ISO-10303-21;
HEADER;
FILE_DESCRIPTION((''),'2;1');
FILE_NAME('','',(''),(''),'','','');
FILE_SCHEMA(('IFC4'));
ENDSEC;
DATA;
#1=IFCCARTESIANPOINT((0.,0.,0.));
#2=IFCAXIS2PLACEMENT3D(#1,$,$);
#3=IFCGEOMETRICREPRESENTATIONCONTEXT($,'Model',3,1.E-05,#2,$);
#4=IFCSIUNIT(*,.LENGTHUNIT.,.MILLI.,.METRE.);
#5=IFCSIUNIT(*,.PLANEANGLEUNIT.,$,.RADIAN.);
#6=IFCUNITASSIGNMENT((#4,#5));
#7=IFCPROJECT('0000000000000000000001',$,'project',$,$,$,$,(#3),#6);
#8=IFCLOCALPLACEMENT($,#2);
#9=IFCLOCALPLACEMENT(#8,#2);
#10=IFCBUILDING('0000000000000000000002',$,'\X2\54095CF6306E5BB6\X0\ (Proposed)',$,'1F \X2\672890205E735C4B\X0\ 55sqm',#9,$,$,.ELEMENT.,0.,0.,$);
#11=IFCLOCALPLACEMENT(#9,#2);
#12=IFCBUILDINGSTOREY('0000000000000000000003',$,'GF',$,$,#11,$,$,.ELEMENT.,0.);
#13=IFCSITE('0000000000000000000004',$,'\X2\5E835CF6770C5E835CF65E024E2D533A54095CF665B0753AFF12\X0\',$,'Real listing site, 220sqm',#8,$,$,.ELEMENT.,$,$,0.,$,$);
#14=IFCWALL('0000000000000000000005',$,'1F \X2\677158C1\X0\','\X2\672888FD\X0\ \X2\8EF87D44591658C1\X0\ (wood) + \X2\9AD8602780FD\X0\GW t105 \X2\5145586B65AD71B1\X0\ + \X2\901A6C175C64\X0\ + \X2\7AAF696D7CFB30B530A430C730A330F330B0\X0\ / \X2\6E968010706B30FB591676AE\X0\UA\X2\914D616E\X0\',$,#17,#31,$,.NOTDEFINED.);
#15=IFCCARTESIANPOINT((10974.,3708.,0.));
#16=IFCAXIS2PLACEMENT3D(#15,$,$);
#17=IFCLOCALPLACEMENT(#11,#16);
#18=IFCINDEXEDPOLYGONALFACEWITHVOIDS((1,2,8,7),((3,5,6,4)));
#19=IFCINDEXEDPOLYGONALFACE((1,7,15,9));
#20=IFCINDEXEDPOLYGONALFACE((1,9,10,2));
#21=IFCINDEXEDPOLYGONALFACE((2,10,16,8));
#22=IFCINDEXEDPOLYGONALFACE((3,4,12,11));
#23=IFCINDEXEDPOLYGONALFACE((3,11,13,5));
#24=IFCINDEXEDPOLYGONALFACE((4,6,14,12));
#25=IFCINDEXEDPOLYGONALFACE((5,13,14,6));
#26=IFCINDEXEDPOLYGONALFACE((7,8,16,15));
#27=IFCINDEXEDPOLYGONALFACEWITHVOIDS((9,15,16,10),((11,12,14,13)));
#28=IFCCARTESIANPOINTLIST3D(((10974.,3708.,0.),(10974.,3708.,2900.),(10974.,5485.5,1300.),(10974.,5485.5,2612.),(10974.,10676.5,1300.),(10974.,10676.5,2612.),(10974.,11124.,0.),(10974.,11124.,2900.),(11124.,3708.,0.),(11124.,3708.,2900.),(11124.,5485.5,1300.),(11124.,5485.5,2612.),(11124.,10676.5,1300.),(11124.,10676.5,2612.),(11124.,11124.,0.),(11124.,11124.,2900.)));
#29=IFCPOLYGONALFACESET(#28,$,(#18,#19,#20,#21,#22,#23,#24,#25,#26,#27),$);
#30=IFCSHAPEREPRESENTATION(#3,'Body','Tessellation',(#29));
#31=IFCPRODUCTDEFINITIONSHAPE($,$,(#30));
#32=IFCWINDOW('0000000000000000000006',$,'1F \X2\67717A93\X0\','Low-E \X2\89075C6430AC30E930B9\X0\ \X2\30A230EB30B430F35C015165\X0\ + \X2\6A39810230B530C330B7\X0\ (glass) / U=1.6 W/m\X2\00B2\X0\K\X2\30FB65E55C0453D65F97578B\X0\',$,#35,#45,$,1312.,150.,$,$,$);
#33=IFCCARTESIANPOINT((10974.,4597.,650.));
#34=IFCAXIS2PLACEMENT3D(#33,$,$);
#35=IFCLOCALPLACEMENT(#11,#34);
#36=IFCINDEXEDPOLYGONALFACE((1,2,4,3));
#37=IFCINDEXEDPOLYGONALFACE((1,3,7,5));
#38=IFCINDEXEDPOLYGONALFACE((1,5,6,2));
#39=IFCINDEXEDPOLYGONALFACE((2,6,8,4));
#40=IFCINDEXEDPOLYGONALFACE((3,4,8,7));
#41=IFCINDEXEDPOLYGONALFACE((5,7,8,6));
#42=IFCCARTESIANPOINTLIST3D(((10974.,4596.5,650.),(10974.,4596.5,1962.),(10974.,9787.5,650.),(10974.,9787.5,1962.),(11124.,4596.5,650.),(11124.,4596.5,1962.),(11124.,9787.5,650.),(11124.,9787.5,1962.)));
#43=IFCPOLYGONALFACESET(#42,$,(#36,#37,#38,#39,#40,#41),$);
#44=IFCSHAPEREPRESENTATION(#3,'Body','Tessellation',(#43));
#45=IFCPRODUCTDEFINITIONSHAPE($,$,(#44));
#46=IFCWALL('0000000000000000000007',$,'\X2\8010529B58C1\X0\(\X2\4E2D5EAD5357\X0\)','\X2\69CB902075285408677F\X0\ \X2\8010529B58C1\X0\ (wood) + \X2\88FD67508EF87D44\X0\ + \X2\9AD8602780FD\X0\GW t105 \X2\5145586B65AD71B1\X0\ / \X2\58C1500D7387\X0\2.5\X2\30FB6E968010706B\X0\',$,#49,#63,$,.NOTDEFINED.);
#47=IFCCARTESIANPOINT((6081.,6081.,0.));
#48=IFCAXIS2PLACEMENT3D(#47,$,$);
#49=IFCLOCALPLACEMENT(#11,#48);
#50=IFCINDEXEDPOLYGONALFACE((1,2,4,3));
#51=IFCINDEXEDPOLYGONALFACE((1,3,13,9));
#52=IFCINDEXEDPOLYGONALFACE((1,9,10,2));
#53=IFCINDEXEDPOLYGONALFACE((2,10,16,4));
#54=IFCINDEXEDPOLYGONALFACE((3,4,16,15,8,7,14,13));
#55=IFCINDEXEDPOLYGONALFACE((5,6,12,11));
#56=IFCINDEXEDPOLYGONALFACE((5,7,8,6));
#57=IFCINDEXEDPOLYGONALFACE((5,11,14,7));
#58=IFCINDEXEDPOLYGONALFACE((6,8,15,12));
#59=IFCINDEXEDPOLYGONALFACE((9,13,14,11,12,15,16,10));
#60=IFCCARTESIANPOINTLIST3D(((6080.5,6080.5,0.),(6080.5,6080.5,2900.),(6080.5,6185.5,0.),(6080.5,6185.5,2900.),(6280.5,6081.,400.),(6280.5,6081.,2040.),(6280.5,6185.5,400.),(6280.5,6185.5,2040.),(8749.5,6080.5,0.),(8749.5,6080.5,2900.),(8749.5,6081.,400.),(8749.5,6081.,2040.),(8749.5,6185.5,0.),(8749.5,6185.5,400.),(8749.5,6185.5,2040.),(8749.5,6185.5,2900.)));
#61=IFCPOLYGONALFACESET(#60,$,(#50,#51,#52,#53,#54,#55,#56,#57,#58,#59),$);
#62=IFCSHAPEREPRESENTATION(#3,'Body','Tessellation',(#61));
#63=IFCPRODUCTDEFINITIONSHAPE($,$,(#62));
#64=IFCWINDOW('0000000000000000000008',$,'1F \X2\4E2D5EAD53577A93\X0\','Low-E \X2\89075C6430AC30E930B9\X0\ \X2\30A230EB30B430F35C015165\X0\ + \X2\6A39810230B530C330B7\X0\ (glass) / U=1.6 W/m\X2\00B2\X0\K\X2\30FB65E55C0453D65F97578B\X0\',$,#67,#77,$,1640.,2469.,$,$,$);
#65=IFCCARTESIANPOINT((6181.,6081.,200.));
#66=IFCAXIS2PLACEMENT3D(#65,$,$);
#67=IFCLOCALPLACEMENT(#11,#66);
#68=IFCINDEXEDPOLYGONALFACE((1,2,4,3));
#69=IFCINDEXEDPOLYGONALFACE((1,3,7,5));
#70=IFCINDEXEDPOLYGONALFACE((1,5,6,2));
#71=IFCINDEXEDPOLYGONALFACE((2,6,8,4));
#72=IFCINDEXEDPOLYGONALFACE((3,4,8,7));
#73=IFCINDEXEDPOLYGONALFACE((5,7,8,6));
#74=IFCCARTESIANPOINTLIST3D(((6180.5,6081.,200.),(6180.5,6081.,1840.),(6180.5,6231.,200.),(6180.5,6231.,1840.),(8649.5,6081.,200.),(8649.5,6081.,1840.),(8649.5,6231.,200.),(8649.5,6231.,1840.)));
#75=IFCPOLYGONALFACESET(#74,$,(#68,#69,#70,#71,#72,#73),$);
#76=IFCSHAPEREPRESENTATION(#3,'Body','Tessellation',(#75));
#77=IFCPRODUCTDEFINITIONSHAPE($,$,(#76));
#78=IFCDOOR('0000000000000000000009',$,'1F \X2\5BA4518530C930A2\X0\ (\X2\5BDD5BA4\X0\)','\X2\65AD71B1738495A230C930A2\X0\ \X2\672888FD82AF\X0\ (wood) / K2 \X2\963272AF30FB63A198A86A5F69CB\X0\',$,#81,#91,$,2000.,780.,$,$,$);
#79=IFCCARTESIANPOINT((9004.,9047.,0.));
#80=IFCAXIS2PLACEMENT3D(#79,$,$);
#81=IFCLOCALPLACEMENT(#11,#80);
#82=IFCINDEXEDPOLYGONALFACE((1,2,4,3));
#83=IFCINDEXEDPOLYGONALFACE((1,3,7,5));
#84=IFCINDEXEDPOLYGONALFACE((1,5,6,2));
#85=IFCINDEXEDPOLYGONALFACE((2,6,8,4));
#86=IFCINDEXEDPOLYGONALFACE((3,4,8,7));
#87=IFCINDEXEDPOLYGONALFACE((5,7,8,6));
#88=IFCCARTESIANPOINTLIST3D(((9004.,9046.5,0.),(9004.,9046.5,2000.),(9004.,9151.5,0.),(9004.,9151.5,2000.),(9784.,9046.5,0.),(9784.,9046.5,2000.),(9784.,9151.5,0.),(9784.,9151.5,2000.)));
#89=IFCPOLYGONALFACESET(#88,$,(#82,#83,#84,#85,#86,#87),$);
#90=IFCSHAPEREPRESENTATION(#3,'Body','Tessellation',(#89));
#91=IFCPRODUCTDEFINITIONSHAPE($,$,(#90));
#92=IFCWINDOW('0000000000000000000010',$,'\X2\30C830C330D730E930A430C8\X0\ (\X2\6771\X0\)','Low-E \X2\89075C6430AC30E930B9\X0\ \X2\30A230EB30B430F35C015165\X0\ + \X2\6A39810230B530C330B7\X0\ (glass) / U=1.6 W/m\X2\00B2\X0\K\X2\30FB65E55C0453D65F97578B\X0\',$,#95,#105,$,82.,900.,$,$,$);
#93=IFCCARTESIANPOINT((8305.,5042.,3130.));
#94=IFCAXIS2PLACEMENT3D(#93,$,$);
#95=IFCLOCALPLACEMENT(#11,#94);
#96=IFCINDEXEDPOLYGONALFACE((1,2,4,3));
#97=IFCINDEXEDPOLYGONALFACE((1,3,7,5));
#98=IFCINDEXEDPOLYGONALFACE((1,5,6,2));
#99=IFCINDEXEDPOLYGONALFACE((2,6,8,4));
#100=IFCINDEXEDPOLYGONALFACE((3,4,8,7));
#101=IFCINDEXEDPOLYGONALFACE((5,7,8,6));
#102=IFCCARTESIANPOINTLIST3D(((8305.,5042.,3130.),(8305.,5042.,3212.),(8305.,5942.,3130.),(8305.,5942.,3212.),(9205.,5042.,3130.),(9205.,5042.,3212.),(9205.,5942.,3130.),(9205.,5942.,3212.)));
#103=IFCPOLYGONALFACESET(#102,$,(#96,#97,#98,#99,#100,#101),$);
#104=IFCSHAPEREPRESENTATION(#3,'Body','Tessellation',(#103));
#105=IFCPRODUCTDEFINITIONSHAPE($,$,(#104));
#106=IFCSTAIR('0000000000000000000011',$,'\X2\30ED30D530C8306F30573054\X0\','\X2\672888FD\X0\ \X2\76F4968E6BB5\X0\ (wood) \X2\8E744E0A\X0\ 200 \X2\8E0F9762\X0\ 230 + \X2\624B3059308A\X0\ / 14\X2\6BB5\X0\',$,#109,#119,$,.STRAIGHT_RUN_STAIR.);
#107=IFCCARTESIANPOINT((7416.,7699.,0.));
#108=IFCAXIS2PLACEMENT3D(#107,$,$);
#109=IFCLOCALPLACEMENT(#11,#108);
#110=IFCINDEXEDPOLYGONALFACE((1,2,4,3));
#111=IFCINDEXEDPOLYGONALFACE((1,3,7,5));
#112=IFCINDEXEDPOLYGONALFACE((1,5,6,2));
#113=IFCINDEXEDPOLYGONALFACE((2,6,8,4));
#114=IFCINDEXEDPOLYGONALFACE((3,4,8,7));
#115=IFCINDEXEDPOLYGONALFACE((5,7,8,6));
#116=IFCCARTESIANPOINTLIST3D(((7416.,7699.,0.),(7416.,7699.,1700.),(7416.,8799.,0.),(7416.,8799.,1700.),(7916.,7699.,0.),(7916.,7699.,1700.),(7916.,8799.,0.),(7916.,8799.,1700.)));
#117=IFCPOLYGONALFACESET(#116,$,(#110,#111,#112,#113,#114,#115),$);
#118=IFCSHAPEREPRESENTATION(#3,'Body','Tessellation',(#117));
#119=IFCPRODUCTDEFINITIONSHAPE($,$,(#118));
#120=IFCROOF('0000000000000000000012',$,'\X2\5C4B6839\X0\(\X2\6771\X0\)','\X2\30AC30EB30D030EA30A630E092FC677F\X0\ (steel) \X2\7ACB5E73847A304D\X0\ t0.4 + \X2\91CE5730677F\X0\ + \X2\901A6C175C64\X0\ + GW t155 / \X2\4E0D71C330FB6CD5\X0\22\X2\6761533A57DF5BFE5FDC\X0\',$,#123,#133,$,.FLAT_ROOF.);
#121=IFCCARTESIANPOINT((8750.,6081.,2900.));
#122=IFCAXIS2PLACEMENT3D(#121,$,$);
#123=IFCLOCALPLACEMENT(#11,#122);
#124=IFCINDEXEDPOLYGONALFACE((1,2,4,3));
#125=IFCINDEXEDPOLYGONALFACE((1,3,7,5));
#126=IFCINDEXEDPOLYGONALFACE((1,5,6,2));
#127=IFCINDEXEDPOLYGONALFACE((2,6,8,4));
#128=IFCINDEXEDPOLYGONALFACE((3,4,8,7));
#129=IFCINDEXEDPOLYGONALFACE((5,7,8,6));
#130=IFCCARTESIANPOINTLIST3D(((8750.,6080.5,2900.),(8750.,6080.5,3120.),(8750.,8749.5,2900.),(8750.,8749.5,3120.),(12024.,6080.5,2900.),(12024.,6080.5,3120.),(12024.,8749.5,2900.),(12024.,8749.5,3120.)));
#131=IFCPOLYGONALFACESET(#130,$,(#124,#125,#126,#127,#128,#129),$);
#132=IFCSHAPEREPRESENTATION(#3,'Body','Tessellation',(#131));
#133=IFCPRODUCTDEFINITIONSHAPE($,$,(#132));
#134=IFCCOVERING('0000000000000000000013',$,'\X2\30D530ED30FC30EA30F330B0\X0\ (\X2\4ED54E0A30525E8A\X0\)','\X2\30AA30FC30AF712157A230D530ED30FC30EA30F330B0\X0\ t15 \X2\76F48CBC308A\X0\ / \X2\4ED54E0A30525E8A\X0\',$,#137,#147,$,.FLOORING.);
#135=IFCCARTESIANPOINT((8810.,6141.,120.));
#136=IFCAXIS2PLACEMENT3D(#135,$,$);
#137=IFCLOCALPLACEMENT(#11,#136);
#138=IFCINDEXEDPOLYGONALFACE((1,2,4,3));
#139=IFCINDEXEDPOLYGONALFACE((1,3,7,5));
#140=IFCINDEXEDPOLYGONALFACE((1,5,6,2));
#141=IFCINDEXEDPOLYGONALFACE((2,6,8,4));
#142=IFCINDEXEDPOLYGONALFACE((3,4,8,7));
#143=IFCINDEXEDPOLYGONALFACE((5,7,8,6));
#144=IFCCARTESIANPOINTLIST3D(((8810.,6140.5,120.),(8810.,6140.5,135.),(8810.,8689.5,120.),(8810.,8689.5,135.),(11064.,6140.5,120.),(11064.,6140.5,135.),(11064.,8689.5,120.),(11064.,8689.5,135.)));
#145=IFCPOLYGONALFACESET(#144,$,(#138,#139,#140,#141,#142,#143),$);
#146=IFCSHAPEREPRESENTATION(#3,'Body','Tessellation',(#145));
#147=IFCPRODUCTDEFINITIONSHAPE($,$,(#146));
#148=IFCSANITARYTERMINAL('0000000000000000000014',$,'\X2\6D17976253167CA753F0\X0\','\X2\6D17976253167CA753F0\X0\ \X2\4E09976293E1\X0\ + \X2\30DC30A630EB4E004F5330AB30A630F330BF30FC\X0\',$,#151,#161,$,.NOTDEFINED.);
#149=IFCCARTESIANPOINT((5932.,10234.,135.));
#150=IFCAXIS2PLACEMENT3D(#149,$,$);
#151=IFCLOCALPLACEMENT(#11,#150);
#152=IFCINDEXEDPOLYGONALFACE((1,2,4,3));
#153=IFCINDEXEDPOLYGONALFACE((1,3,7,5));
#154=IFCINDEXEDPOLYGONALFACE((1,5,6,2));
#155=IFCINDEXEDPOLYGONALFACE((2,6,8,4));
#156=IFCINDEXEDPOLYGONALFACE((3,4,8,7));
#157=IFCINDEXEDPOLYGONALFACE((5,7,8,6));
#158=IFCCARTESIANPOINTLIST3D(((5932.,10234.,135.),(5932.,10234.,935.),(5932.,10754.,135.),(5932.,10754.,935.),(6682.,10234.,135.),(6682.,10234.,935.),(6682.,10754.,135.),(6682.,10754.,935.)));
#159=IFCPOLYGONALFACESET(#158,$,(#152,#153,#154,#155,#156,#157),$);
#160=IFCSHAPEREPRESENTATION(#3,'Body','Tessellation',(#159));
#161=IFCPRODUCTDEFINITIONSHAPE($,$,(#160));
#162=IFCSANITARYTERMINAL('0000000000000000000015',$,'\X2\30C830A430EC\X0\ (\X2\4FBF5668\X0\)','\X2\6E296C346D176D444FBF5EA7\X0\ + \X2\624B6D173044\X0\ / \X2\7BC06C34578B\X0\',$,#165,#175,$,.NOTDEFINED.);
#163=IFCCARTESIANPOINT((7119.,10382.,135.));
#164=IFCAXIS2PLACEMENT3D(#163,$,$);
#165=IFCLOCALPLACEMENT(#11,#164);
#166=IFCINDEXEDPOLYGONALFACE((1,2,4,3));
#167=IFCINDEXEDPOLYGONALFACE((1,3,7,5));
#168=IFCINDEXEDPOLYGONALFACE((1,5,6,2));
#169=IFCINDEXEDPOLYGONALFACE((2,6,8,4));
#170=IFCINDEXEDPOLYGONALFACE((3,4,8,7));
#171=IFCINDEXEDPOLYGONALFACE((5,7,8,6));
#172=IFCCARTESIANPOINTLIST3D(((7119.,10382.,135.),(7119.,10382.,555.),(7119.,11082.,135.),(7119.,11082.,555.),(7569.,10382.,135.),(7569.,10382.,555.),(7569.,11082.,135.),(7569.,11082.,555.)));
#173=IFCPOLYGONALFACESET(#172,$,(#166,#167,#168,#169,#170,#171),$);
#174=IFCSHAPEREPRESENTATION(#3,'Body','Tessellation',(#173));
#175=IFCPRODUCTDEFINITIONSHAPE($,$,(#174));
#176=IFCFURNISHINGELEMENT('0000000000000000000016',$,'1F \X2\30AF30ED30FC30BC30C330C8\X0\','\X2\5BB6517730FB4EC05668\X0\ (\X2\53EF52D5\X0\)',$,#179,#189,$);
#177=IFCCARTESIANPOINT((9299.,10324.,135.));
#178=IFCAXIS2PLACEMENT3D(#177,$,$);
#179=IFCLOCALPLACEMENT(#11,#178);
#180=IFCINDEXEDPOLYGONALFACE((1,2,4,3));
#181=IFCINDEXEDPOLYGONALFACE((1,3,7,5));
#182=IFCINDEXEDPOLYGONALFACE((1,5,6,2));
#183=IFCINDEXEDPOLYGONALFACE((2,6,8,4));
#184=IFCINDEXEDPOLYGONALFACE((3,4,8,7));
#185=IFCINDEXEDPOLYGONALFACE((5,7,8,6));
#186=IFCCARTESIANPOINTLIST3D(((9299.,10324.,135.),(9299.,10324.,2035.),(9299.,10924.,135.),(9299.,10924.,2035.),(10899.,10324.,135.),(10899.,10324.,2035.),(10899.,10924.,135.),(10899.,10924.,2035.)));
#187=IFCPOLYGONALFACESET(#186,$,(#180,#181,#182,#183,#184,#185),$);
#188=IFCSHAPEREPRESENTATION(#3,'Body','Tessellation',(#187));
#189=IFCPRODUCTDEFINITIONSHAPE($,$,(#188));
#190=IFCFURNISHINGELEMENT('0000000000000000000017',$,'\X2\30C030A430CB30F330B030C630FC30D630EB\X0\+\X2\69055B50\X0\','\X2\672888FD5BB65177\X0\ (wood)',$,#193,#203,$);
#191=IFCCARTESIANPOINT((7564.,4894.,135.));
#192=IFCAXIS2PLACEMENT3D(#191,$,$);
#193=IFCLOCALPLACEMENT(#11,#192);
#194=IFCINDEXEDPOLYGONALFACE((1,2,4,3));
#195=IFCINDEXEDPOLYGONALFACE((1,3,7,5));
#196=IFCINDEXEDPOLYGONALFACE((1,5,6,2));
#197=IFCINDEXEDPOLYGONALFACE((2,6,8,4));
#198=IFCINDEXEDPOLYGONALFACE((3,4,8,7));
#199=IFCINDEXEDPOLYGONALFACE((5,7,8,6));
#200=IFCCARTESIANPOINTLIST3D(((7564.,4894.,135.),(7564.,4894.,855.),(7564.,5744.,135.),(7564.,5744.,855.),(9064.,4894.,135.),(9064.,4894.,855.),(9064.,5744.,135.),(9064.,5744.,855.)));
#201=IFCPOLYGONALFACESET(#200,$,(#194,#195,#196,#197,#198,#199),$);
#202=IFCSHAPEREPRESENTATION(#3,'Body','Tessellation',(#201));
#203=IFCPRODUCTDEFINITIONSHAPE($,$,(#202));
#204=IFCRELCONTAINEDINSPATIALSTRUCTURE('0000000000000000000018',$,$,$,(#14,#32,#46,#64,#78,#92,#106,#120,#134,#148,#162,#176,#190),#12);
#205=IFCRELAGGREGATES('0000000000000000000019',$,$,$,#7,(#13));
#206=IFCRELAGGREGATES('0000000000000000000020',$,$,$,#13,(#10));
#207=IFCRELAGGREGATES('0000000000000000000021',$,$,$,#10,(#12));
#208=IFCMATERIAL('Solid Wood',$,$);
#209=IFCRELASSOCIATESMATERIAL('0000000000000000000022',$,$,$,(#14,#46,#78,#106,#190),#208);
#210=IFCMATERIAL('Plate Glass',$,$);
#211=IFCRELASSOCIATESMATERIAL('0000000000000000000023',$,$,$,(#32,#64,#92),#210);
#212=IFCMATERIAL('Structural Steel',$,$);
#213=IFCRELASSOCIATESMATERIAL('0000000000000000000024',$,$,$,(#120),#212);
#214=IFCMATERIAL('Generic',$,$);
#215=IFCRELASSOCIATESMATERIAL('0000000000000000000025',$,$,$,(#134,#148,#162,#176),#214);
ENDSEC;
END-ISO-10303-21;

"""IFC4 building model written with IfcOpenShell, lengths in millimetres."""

from ifc_helpers import new_model, si_unit, frame, frame_2d, origin, place, context, project, spatial, rectangle, extrude, material, element, fill, save


model = new_model("IFC4")

# Units and contexts
model_context = context("Model", 3, precision=1e-05, world=origin())
ifc_project = project(units=[si_unit("LENGTHUNIT", "METRE", prefix="MILLI"), si_unit("PLANEANGLEUNIT", "RADIAN")], contexts=[model_context])

# Site, building, storey
site_placement = place(None, origin())
site = spatial("IfcSite", under=ifc_project, at=site_placement, Name="広島県広島市中区吉島新町２", ObjectType="Real listing site, 220sqm", CompositionType="ELEMENT", RefElevation=0.0)
building_placement = place(site_placement, origin())
building = spatial("IfcBuilding", under=site, at=building_placement, Name="吉島の家 (Proposed)", ObjectType="1F 木造平屋 55sqm", CompositionType="ELEMENT", ElevationOfRefHeight=0.0, ElevationOfTerrain=0.0)
storey_placement = place(building_placement, origin())
storey = spatial("IfcBuildingStorey", under=building, at=storey_placement, Name="GF", CompositionType="ELEMENT", Elevation=0.0)

# Shared definitions
ifc_material_1 = material(Name="Solid Wood")

# Walls, openings, windows
wall_1_placement = place(storey_placement, frame((10974.0, 3708.0, 0.0)))
wall_1 = element("IfcWall", 1, at=wall_1_placement, inside=storey, material=ifc_material_1, Name="1F 東壁", Description="木製 軸組外壁 (wood) + 高性能GW t105 充填断熱 + 通気層 + 窯業系サイディング / 準耐火・外皮UA配慮", PredefinedType="NOTDEFINED", context=model_context, shape_type="SweptSolid", body=[
    extrude(rectangle(XDim=150.0, YDim=7416.0, at=frame_2d((75.0, 3708.0))), frame((10974.0, 3708.0, 0.0)), (0.0, 0.0, 1.0), 2900.0),
])
opening_1_placement = place(storey_placement, frame((10974.0, 4597.0, 650.0)))
opening_1 = element("IfcOpeningElement", 2, at=opening_1_placement, cuts=wall_1, PredefinedType="NOTDEFINED", context=model_context, shape_type="SweptSolid", body=[
    extrude(rectangle(XDim=150.0, YDim=5191.0, at=frame_2d((75.0, 2595.0))), frame((10974.0, 4597.0, 650.0)), (0.0, 0.0, 1.0), 1312.0),
])
ifc_material_2 = material(Name="Plate Glass")
window_1_placement = place(storey_placement, frame((10974.0, 4597.0, 650.0)))
window_1 = element("IfcWindow", 3, at=window_1_placement, inside=storey, material=ifc_material_2, Name="1F 東窓", Description="Low-E 複層ガラス アルゴン封入 + 樹脂サッシ (glass) / U=1.6 W/m²K・日射取得型", OverallHeight=1312.0, OverallWidth=150.0, context=model_context, shape_type="SweptSolid", body=[
    extrude(rectangle(XDim=150.0, YDim=5191.0, at=frame_2d((75.0, 2595.0))), frame((10974.0, 4597.0, 650.0)), (0.0, 0.0, 1.0), 1312.0),
])
fill(opening_1, window_1)
wall_2_placement = place(storey_placement, frame((6081.0, 6081.0, 0.0)))
wall_2 = element("IfcWall", 4, at=wall_2_placement, inside=storey, material=ifc_material_1, Name="耐力壁(中庭南)", Description="構造用合板 耐力壁 (wood) + 製材軸組 + 高性能GW t105 充填断熱 / 壁倍率2.5・準耐火", PredefinedType="NOTDEFINED", context=model_context, shape_type="SweptSolid", body=[
    extrude(rectangle(XDim=2669.0, YDim=105.0, at=frame_2d((1334.0, 52.0))), frame((6081.0, 6081.0, 0.0)), (0.0, 0.0, 1.0), 2900.0),
])
opening_2_placement = place(storey_placement, frame((6181.0, 6081.0, 200.0)))
opening_2 = element("IfcOpeningElement", 5, at=opening_2_placement, cuts=wall_2, PredefinedType="NOTDEFINED", context=model_context, shape_type="SweptSolid", body=[
    extrude(rectangle(XDim=2469.0, YDim=150.0, at=frame_2d((1234.0, 75.0))), frame((6181.0, 6081.0, 200.0)), (0.0, 0.0, 1.0), 1640.0),
])
window_2_placement = place(storey_placement, frame((6181.0, 6081.0, 200.0)))
window_2 = element("IfcWindow", 6, at=window_2_placement, inside=storey, material=ifc_material_2, Name="1F 中庭南窓", Description="Low-E 複層ガラス アルゴン封入 + 樹脂サッシ (glass) / U=1.6 W/m²K・日射取得型", OverallHeight=1640.0, OverallWidth=2469.0, context=model_context, shape_type="SweptSolid", body=[
    extrude(rectangle(XDim=2469.0, YDim=150.0, at=frame_2d((1234.0, 75.0))), frame((6181.0, 6081.0, 200.0)), (0.0, 0.0, 1.0), 1640.0),
])
fill(opening_2, window_2)

# Door
door_placement = place(storey_placement, frame((9004.0, 9047.0, 0.0)))
element("IfcDoor", 7, at=door_placement, inside=storey, material=ifc_material_1, Name="1F 室内ドア (寝室)", Description="断熱玄関ドア 木製芯 (wood) / K2 防犯・採風機構", OverallHeight=2000.0, OverallWidth=780.0, context=model_context, shape_type="SweptSolid", body=[
    extrude(rectangle(XDim=780.0, YDim=105.0, at=frame_2d((390.0, 52.0))), frame((9004.0, 9047.0, 0.0)), (0.0, 0.0, 1.0), 2000.0),
])

# Window
window_3_placement = place(storey_placement, frame((8305.0, 5042.0, 3130.0)))
element("IfcWindow", 8, at=window_3_placement, inside=storey, material=ifc_material_2, Name="トップライト (東)", Description="Low-E 複層ガラス アルゴン封入 + 樹脂サッシ (glass) / U=1.6 W/m²K・日射取得型", OverallHeight=82.0, OverallWidth=900.0, context=model_context, shape_type="SweptSolid", body=[
    extrude(rectangle(XDim=900.0, YDim=900.0, at=frame_2d((450.0, 450.0))), frame((8305.0, 5042.0, 3130.0)), (0.0, 0.0, 1.0), 82.0),
])

# Stair
stair_placement = place(storey_placement, frame((7416.0, 7699.0, 0.0)))
element("IfcStair", 9, at=stair_placement, inside=storey, material=ifc_material_1, Name="ロフトはしご", Description="木製 直階段 (wood) 蹴上 200 踏面 230 + 手すり / 14段", PredefinedType="STRAIGHT_RUN_STAIR", context=model_context, shape_type="SweptSolid", body=[
    extrude(rectangle(XDim=500.0, YDim=1100.0, at=frame_2d((250.0, 550.0))), frame((7416.0, 7699.0, 0.0)), (0.0, 0.0, 1.0), 1700.0),
])

# Roof
ifc_material_3 = material(Name="Structural Steel")
roof_placement = place(storey_placement, frame((8750.0, 6081.0, 2900.0)))
element("IfcRoof", 10, at=roof_placement, inside=storey, material=ifc_material_3, Name="屋根(東)", Description="ガルバリウム鋼板 (steel) 立平葺き t0.4 + 野地板 + 通気層 + GW t155 / 不燃・法22条区域対応", PredefinedType="FLAT_ROOF", context=model_context, shape_type="SweptSolid", body=[
    extrude(rectangle(XDim=3274.0, YDim=2669.0, at=frame_2d((1637.0, 1334.0))), frame((8750.0, 6081.0, 2900.0)), (0.0, 0.0, 1.0), 220.0),
])

# Covering
ifc_material_4 = material(Name="Generic")
covering_placement = place(storey_placement, frame((8810.0, 6141.0, 120.0)))
element("IfcCovering", 11, at=covering_placement, inside=storey, material=ifc_material_4, Name="フローリング (仕上げ床)", Description="オーク無垢フローリング t15 直貼り / 仕上げ床", PredefinedType="FLOORING", context=model_context, shape_type="SweptSolid", body=[
    extrude(rectangle(XDim=2254.0, YDim=2549.0, at=frame_2d((1127.0, 1274.0))), frame((8810.0, 6141.0, 120.0)), (0.0, 0.0, 1.0), 15.0),
])

# Sanitary terminals
sanitary_terminal_1_placement = place(storey_placement, frame((5932.0, 10234.0, 135.0)))
element("IfcSanitaryTerminal", 12, at=sanitary_terminal_1_placement, inside=storey, material=ifc_material_4, Name="洗面化粧台", Description="洗面化粧台 三面鏡 + ボウル一体カウンター", PredefinedType="NOTDEFINED", context=model_context, shape_type="SweptSolid", body=[
    extrude(rectangle(XDim=750.0, YDim=520.0, at=frame_2d((375.0, 260.0))), frame((5932.0, 10234.0, 135.0)), (0.0, 0.0, 1.0), 800.0),
])
sanitary_terminal_2_placement = place(storey_placement, frame((7119.0, 10382.0, 135.0)))
element("IfcSanitaryTerminal", 13, at=sanitary_terminal_2_placement, inside=storey, material=ifc_material_4, Name="トイレ (便器)", Description="温水洗浄便座 + 手洗い / 節水型", PredefinedType="NOTDEFINED", context=model_context, shape_type="SweptSolid", body=[
    extrude(rectangle(XDim=450.0, YDim=700.0, at=frame_2d((225.0, 350.0))), frame((7119.0, 10382.0, 135.0)), (0.0, 0.0, 1.0), 420.0),
])

# Furnishing elements
furnishing_1_placement = place(storey_placement, frame((9299.0, 10324.0, 135.0)))
element("IfcFurnishingElement", 14, at=furnishing_1_placement, inside=storey, material=ifc_material_4, Name="1F クローゼット", Description="家具・什器 (可動)", context=model_context, shape_type="SweptSolid", body=[
    extrude(rectangle(XDim=1600.0, YDim=600.0, at=frame_2d((800.0, 300.0))), frame((9299.0, 10324.0, 135.0)), (0.0, 0.0, 1.0), 1900.0),
])
furnishing_2_placement = place(storey_placement, frame((7564.0, 4894.0, 135.0)))
element("IfcFurnishingElement", 15, at=furnishing_2_placement, inside=storey, material=ifc_material_1, Name="ダイニングテーブル+椅子", Description="木製家具 (wood)", context=model_context, shape_type="SweptSolid", body=[
    extrude(rectangle(XDim=1500.0, YDim=850.0, at=frame_2d((750.0, 425.0))), frame((7564.0, 4894.0, 135.0)), (0.0, 0.0, 1.0), 720.0),
])

save(model, "model.ifc")
